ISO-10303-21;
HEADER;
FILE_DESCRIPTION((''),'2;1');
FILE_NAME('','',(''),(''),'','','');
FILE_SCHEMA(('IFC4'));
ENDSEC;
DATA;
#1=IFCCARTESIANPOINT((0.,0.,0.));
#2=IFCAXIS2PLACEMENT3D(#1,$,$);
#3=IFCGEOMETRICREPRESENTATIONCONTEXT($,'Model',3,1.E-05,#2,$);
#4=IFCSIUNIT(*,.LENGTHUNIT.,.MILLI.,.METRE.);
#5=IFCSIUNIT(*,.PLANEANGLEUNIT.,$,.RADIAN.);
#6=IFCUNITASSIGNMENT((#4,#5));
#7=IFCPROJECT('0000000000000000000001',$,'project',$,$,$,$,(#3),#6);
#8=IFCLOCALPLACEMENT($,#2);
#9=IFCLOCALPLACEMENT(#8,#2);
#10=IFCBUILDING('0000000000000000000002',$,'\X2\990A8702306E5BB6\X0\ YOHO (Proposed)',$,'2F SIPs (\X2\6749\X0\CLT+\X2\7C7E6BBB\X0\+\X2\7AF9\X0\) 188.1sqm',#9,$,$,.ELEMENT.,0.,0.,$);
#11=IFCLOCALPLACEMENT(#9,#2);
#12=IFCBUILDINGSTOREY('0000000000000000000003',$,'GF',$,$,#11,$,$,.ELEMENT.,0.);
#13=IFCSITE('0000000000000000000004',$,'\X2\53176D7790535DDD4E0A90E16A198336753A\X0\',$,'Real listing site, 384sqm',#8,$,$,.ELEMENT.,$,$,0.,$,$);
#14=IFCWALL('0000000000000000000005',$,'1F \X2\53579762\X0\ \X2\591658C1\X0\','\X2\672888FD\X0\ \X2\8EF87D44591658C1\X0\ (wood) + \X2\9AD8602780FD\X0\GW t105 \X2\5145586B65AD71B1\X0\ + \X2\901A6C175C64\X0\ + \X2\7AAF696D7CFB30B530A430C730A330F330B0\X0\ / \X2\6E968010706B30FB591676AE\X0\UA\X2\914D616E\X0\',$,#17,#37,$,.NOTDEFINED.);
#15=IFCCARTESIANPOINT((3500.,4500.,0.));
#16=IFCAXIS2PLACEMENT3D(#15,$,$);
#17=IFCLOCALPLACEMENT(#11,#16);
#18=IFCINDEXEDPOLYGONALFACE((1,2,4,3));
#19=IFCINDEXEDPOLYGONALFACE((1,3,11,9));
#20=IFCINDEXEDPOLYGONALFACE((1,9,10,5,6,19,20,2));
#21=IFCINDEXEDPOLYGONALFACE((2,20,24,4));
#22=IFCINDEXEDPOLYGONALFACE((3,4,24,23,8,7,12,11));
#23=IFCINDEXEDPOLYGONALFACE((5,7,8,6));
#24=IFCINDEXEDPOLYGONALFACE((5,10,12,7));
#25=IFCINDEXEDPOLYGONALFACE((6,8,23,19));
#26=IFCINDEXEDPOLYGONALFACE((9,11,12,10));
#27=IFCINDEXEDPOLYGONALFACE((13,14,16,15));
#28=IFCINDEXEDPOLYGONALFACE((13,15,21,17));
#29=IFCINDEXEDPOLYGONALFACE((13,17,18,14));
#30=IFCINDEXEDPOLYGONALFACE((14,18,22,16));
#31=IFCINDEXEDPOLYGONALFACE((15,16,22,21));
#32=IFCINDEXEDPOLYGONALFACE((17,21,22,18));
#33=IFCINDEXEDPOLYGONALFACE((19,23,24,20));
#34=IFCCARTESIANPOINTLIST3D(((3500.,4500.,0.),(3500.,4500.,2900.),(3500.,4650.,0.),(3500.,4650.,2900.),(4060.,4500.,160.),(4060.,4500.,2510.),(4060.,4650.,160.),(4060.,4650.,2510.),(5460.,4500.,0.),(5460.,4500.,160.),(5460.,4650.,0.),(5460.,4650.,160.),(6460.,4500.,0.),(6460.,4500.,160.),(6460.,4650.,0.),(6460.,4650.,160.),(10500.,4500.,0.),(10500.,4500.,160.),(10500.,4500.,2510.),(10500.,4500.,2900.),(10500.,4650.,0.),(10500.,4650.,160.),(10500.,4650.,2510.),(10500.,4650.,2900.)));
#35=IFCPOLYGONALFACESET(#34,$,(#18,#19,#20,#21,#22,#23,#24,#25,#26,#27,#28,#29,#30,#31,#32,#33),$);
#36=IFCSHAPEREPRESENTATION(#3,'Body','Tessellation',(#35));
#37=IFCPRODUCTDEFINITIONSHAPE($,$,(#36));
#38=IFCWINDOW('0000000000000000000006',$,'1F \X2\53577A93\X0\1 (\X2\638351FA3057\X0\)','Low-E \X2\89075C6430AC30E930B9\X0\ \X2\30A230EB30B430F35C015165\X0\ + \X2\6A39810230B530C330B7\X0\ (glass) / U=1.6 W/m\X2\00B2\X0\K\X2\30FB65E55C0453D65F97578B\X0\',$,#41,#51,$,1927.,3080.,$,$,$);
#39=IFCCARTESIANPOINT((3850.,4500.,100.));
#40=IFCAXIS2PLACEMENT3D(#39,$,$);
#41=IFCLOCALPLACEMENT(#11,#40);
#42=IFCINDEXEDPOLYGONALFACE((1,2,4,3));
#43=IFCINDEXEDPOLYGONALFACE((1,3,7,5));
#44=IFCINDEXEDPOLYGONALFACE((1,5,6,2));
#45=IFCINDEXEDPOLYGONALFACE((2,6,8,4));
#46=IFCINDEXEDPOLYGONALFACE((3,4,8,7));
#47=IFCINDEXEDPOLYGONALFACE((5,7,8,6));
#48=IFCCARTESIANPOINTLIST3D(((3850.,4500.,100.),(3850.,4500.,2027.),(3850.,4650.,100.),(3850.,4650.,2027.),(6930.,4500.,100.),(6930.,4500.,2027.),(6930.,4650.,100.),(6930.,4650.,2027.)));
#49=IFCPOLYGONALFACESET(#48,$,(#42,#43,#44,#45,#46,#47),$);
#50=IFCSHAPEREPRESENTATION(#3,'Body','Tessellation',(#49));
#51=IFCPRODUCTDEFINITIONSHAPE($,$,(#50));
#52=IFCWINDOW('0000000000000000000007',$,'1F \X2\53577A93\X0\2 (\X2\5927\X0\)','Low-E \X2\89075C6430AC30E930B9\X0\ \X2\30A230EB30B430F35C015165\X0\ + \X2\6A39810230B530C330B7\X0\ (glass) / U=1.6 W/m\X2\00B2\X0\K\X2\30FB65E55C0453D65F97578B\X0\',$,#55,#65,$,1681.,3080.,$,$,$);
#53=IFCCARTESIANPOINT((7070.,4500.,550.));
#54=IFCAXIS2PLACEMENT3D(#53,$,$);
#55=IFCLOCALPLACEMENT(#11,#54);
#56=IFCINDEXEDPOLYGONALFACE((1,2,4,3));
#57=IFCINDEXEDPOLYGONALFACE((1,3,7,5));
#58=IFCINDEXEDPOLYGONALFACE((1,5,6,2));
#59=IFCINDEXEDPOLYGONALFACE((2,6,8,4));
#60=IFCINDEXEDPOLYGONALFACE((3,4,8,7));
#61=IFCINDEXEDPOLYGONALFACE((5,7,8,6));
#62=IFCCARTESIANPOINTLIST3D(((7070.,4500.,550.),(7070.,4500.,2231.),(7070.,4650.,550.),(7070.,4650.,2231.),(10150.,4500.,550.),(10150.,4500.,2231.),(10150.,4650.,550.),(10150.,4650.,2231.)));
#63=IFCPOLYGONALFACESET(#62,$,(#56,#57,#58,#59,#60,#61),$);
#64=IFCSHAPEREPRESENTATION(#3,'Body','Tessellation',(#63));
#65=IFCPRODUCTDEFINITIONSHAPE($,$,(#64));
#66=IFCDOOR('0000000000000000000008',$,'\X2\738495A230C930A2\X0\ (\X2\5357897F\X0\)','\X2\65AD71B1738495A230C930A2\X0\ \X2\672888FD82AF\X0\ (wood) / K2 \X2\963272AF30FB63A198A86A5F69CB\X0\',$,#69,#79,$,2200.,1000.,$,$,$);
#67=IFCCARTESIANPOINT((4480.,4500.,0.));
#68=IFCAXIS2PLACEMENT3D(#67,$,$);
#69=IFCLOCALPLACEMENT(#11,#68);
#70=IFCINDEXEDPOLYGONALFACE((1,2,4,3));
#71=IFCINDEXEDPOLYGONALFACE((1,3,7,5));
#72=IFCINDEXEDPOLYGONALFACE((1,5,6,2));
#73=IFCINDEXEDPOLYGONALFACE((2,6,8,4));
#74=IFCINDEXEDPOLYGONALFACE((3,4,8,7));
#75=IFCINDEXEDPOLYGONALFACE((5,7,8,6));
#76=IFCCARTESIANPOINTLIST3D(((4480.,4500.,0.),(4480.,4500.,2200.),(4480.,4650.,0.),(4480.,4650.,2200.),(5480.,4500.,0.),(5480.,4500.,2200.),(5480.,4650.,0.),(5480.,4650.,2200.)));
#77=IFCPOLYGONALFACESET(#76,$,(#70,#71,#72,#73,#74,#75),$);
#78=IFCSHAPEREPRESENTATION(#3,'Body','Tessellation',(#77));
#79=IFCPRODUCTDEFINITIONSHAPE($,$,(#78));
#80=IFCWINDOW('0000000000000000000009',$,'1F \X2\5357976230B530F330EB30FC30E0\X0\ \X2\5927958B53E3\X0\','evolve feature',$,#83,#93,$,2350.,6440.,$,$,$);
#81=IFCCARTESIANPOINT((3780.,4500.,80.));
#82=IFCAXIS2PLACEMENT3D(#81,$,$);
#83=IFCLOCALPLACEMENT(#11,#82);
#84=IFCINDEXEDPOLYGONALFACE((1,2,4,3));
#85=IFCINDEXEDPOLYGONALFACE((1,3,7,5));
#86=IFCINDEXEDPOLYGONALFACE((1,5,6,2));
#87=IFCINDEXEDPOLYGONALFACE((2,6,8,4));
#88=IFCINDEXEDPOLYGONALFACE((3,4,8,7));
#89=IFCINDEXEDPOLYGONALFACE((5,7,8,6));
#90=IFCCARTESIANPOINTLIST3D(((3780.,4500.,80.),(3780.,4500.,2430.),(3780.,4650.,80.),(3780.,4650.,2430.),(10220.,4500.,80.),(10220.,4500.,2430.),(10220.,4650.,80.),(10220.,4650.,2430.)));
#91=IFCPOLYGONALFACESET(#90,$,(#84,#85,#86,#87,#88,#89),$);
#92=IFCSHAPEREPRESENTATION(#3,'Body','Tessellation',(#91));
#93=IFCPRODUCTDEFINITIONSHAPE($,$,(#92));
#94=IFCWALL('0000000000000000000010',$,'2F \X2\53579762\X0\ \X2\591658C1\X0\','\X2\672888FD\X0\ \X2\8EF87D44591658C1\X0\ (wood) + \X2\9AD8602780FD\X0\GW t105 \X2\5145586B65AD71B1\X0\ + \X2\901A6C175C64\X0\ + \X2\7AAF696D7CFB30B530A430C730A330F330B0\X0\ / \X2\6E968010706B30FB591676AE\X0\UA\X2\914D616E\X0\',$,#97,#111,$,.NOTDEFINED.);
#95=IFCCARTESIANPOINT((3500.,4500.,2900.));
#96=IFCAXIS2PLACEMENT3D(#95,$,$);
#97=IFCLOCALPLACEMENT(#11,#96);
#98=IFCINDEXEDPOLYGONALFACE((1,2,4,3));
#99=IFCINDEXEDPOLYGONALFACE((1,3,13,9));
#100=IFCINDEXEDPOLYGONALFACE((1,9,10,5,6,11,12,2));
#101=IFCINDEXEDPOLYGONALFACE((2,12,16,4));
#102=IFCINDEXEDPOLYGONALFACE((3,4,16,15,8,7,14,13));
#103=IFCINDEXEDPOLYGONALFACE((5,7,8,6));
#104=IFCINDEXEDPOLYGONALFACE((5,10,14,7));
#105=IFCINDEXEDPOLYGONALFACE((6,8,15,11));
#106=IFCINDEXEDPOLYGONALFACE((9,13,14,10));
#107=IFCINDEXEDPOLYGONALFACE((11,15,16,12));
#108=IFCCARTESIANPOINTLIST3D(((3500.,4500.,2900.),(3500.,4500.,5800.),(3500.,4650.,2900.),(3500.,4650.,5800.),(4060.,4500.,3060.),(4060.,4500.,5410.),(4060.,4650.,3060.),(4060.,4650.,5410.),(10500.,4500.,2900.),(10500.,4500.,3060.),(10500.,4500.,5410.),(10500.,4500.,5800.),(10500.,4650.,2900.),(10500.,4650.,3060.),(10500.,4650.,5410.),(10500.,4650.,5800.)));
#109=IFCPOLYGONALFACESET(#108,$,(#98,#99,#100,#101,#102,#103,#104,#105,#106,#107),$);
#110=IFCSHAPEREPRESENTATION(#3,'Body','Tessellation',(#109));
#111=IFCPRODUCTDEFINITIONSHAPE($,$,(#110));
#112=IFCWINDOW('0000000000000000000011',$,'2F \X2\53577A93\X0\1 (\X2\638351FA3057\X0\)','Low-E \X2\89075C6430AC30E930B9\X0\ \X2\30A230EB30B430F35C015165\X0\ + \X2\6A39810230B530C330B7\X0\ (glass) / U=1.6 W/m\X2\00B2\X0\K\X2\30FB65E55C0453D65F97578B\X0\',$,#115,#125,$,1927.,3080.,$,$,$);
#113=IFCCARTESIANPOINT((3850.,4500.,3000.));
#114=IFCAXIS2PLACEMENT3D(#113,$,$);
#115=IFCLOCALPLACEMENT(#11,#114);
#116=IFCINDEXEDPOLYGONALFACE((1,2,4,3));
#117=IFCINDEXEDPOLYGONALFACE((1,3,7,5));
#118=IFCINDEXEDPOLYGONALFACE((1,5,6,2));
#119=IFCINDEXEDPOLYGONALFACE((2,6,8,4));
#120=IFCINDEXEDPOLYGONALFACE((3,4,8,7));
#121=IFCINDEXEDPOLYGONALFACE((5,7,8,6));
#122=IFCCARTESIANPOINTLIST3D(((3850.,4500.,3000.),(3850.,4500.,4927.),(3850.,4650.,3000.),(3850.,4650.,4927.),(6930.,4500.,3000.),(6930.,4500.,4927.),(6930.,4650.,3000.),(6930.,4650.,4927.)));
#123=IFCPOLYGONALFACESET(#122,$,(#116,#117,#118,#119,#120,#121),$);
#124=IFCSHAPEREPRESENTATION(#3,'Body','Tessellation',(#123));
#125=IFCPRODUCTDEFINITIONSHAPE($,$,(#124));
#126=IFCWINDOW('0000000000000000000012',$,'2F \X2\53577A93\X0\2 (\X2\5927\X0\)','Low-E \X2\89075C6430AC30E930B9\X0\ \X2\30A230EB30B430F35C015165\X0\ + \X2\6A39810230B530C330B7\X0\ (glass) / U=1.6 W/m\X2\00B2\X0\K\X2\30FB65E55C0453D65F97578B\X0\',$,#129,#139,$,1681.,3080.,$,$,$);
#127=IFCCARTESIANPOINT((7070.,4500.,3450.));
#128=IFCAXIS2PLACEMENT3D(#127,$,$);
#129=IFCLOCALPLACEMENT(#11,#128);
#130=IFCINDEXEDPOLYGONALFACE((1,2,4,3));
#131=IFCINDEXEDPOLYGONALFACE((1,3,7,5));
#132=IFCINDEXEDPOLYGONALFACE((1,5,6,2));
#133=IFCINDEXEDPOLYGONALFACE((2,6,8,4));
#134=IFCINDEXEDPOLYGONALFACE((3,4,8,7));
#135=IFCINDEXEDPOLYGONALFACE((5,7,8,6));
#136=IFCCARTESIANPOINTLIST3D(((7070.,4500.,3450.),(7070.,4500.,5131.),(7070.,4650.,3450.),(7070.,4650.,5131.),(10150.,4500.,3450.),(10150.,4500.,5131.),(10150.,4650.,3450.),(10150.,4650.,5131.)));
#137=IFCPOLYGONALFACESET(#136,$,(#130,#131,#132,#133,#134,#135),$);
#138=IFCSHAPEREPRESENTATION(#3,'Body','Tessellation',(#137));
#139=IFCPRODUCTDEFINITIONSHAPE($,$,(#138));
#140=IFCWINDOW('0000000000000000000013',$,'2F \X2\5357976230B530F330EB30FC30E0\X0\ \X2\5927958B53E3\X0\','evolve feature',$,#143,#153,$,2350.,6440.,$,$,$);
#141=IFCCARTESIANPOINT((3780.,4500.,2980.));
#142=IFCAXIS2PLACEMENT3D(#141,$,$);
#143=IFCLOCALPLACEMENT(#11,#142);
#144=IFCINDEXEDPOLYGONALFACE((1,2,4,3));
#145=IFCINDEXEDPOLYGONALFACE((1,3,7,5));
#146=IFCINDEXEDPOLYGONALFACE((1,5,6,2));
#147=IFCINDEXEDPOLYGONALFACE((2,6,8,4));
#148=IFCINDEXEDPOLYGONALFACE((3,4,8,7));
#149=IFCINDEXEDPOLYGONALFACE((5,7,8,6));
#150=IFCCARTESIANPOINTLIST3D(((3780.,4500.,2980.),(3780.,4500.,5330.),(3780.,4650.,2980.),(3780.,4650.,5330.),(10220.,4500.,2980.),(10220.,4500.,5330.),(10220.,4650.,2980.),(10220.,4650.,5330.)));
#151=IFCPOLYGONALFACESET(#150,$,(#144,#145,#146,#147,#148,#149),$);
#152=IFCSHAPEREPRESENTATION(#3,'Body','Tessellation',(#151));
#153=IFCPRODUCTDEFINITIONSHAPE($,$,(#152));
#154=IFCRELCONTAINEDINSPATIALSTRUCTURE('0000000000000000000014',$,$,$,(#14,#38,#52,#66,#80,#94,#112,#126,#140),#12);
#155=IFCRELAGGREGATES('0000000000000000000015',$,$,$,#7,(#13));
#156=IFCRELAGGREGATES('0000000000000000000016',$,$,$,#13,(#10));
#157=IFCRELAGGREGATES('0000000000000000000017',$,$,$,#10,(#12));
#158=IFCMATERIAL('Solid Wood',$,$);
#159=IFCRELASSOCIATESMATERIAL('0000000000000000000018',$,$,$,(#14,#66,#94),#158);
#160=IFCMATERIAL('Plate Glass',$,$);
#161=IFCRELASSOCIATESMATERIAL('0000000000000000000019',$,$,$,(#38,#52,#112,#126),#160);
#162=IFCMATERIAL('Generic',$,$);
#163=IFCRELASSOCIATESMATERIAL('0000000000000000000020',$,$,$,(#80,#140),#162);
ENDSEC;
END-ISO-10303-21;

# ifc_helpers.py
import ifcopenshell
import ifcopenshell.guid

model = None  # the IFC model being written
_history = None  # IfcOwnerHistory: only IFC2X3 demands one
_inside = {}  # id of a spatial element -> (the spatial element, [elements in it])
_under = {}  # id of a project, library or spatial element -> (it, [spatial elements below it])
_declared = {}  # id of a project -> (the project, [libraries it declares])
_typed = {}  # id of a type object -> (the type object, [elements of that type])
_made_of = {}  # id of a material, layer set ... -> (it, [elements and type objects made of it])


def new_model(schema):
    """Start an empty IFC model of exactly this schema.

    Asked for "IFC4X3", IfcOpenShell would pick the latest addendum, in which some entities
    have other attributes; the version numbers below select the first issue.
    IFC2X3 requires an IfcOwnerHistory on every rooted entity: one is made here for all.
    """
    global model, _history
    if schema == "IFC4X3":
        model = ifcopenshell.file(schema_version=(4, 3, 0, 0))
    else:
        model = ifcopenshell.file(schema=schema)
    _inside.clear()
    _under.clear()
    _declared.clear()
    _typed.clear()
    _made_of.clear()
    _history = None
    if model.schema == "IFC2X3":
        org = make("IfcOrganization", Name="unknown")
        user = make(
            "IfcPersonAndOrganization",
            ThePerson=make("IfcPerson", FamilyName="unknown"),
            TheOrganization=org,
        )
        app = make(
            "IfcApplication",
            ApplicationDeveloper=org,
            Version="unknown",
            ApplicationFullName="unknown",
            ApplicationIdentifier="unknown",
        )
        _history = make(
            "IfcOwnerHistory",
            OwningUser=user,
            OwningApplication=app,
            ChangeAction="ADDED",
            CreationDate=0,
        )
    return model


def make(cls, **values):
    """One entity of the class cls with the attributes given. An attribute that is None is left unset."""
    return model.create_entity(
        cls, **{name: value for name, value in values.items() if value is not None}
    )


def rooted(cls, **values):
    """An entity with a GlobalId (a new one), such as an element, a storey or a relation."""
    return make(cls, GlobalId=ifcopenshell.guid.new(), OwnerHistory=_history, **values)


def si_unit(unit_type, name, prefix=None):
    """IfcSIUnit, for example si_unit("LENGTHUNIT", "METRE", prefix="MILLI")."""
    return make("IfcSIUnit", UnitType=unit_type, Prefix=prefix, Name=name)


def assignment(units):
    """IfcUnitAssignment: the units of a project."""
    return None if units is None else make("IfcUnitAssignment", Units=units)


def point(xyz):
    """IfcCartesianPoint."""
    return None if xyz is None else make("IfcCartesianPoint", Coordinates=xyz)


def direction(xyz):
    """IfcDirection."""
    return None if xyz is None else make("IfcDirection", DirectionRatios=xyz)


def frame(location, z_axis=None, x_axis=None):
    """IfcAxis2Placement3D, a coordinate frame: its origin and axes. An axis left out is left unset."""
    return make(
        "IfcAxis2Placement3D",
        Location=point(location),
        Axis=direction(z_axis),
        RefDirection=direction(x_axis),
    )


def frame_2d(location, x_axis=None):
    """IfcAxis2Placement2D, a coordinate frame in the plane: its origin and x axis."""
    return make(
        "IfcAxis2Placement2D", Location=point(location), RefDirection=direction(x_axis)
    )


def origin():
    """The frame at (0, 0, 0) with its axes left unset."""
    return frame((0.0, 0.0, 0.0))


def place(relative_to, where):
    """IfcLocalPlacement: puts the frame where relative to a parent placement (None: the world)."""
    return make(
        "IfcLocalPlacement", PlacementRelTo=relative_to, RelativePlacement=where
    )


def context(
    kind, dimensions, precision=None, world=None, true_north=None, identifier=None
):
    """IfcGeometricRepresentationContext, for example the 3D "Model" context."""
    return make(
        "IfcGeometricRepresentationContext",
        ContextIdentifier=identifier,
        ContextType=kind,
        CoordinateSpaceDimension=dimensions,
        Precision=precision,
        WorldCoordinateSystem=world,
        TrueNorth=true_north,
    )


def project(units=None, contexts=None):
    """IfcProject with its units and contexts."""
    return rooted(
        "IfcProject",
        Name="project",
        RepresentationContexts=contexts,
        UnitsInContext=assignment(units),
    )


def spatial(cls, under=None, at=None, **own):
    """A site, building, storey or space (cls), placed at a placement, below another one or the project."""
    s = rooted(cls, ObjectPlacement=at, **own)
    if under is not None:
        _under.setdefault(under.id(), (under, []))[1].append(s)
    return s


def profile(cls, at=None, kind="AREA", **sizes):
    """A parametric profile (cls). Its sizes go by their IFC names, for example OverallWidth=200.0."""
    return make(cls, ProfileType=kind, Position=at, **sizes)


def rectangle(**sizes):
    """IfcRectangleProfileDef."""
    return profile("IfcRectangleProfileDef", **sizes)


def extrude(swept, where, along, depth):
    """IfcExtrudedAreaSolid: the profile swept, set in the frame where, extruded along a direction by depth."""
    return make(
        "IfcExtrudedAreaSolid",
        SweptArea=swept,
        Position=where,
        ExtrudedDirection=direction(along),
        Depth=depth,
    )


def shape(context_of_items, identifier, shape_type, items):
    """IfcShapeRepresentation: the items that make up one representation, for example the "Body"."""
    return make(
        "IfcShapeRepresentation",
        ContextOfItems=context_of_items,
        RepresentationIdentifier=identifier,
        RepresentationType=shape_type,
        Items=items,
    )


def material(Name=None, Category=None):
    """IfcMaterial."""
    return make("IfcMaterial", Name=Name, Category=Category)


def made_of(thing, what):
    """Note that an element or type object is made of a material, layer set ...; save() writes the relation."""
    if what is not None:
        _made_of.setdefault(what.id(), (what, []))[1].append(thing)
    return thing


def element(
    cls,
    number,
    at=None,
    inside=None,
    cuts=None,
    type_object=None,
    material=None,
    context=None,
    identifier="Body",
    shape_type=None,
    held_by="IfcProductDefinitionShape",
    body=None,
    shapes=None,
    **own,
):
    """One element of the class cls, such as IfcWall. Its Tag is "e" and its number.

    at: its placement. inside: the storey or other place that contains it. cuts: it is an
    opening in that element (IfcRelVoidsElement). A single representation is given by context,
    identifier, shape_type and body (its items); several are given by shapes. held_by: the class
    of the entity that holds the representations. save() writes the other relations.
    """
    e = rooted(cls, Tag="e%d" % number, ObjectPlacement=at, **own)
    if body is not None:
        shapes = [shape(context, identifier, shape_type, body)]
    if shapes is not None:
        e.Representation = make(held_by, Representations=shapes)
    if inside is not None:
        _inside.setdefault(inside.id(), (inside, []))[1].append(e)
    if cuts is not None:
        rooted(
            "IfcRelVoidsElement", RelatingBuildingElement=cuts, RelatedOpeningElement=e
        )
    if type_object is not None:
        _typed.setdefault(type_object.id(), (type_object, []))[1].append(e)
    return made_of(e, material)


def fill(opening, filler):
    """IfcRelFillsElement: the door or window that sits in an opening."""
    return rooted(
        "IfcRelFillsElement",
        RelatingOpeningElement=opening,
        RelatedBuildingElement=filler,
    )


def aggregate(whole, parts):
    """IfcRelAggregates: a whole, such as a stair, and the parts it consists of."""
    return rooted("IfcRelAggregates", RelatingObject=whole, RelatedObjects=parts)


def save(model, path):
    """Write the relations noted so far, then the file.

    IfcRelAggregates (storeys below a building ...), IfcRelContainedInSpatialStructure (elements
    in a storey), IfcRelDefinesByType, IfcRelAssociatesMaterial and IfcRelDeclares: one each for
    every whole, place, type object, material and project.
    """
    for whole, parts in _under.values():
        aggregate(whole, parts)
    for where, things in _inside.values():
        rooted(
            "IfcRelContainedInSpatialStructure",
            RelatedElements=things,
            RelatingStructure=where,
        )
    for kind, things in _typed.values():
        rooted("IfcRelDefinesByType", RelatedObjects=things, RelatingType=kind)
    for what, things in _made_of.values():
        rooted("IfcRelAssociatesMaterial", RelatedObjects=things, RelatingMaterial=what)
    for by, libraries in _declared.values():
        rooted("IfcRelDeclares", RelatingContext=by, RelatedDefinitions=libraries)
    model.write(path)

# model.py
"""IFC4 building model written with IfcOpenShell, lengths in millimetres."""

from ifc_helpers import new_model, si_unit, frame, frame_2d, origin, place, context, project, spatial, rectangle, extrude, material, element, fill, save


model = new_model("IFC4")

# Units and contexts
model_context = context("Model", 3, precision=1e-05, world=origin())
ifc_project = project(units=[si_unit("LENGTHUNIT", "METRE", prefix="MILLI"), si_unit("PLANEANGLEUNIT", "RADIAN")], contexts=[model_context])

# Site, building, storey
site_placement = place(None, origin())
site = spatial("IfcSite", under=ifc_project, at=site_placement, Name="北海道川上郡標茶町", ObjectType="Real listing site, 384sqm", CompositionType="ELEMENT", RefElevation=0.0)
building_placement = place(site_placement, origin())
building = spatial("IfcBuilding", under=site, at=building_placement, Name="養蜂の家 YOHO (Proposed)", ObjectType="2F SIPs (杉CLT+籾殻+竹) 188.1sqm", CompositionType="ELEMENT", ElevationOfRefHeight=0.0, ElevationOfTerrain=0.0)
storey_placement = place(building_placement, origin())
storey = spatial("IfcBuildingStorey", under=building, at=storey_placement, Name="GF", CompositionType="ELEMENT", Elevation=0.0)

# Shared definitions
ifc_material_1 = material(Name="Solid Wood")

# Wall, openings, windows, door
wall_1_placement = place(storey_placement, frame((3500.0, 4500.0, 0.0)))
wall_1 = element("IfcWall", 1, at=wall_1_placement, inside=storey, material=ifc_material_1, Name="1F 南面 外壁", Description="木製 軸組外壁 (wood) + 高性能GW t105 充填断熱 + 通気層 + 窯業系サイディング / 準耐火・外皮UA配慮", PredefinedType="NOTDEFINED", context=model_context, shape_type="SweptSolid", body=[
    extrude(rectangle(XDim=7000.0, YDim=150.0, at=frame_2d((3500.0, 75.0))), frame((3500.0, 4500.0, 0.0)), (0.0, 0.0, 1.0), 2900.0),
])
opening_1_placement = place(storey_placement, frame((3850.0, 4500.0, 100.0)))
opening_1 = element("IfcOpeningElement", 2, at=opening_1_placement, cuts=wall_1, PredefinedType="NOTDEFINED", context=model_context, shape_type="SweptSolid", body=[
    extrude(rectangle(XDim=3080.0, YDim=150.0, at=frame_2d((1540.0, 75.0))), frame((3850.0, 4500.0, 100.0)), (0.0, 0.0, 1.0), 1927.0),
])
opening_2_placement = place(storey_placement, frame((7070.0, 4500.0, 550.0)))
opening_2 = element("IfcOpeningElement", 3, at=opening_2_placement, cuts=wall_1, PredefinedType="NOTDEFINED", context=model_context, shape_type="SweptSolid", body=[
    extrude(rectangle(XDim=3080.0, YDim=150.0, at=frame_2d((1540.0, 75.0))), frame((7070.0, 4500.0, 550.0)), (0.0, 0.0, 1.0), 1681.0),
])
opening_3_placement = place(storey_placement, frame((4480.0, 4500.0, 0.0)))
opening_3 = element("IfcOpeningElement", 4, at=opening_3_placement, cuts=wall_1, PredefinedType="NOTDEFINED", context=model_context, shape_type="SweptSolid", body=[
    extrude(rectangle(XDim=1000.0, YDim=150.0, at=frame_2d((500.0, 75.0))), frame((4480.0, 4500.0, 0.0)), (0.0, 0.0, 1.0), 2200.0),
])
opening_4_placement = place(storey_placement, frame((3780.0, 4500.0, 80.0)))
opening_4 = element("IfcOpeningElement", 5, at=opening_4_placement, cuts=wall_1, PredefinedType="NOTDEFINED", context=model_context, shape_type="SweptSolid", body=[
    extrude(rectangle(XDim=6440.0, YDim=150.0, at=frame_2d((3220.0, 75.0))), frame((3780.0, 4500.0, 80.0)), (0.0, 0.0, 1.0), 2350.0),
])
ifc_material_2 = material(Name="Plate Glass")
window_1_placement = place(storey_placement, frame((3850.0, 4500.0, 100.0)))
window_1 = element("IfcWindow", 6, at=window_1_placement, inside=storey, material=ifc_material_2, Name="1F 南窓1 (掃出し)", Description="Low-E 複層ガラス アルゴン封入 + 樹脂サッシ (glass) / U=1.6 W/m²K・日射取得型", OverallHeight=1927.0, OverallWidth=3080.0, context=model_context, shape_type="SweptSolid", body=[
    extrude(rectangle(XDim=3080.0, YDim=150.0, at=frame_2d((1540.0, 75.0))), frame((3850.0, 4500.0, 100.0)), (0.0, 0.0, 1.0), 1927.0),
])
fill(opening_1, window_1)
window_2_placement = place(storey_placement, frame((7070.0, 4500.0, 550.0)))
window_2 = element("IfcWindow", 7, at=window_2_placement, inside=storey, material=ifc_material_2, Name="1F 南窓2 (大)", Description="Low-E 複層ガラス アルゴン封入 + 樹脂サッシ (glass) / U=1.6 W/m²K・日射取得型", OverallHeight=1681.0, OverallWidth=3080.0, context=model_context, shape_type="SweptSolid", body=[
    extrude(rectangle(XDim=3080.0, YDim=150.0, at=frame_2d((1540.0, 75.0))), frame((7070.0, 4500.0, 550.0)), (0.0, 0.0, 1.0), 1681.0),
])
fill(opening_2, window_2)
door_placement = place(storey_placement, frame((4480.0, 4500.0, 0.0)))
door = element("IfcDoor", 8, at=door_placement, inside=storey, material=ifc_material_1, Name="玄関ドア (南西)", Description="断熱玄関ドア 木製芯 (wood) / K2 防犯・採風機構", OverallHeight=2200.0, OverallWidth=1000.0, context=model_context, shape_type="SweptSolid", body=[
    extrude(rectangle(XDim=1000.0, YDim=150.0, at=frame_2d((500.0, 75.0))), frame((4480.0, 4500.0, 0.0)), (0.0, 0.0, 1.0), 2200.0),
])
fill(opening_3, door)
ifc_material_3 = material(Name="Generic")
window_3_placement = place(storey_placement, frame((3780.0, 4500.0, 80.0)))
window_3 = element("IfcWindow", 9, at=window_3_placement, inside=storey, material=ifc_material_3, Name="1F 南面サンルーム 大開口", Description="evolve feature", OverallHeight=2350.0, OverallWidth=6440.0, context=model_context, shape_type="SweptSolid", body=[
    extrude(rectangle(XDim=6440.0, YDim=150.0, at=frame_2d((3220.0, 75.0))), frame((3780.0, 4500.0, 80.0)), (0.0, 0.0, 1.0), 2350.0),
])
fill(opening_4, window_3)

# Wall, openings, windows
wall_2_placement = place(storey_placement, frame((3500.0, 4500.0, 2900.0)))
wall_2 = element("IfcWall", 10, at=wall_2_placement, inside=storey, material=ifc_material_1, Name="2F 南面 外壁", Description="木製 軸組外壁 (wood) + 高性能GW t105 充填断熱 + 通気層 + 窯業系サイディング / 準耐火・外皮UA配慮", PredefinedType="NOTDEFINED", context=model_context, shape_type="SweptSolid", body=[
    extrude(rectangle(XDim=7000.0, YDim=150.0, at=frame_2d((3500.0, 75.0))), frame((3500.0, 4500.0, 2900.0)), (0.0, 0.0, 1.0), 2900.0),
])
opening_5_placement = place(storey_placement, frame((3850.0, 4500.0, 3000.0)))
opening_5 = element("IfcOpeningElement", 11, at=opening_5_placement, cuts=wall_2, PredefinedType="NOTDEFINED", context=model_context, shape_type="SweptSolid", body=[
    extrude(rectangle(XDim=3080.0, YDim=150.0, at=frame_2d((1540.0, 75.0))), frame((3850.0, 4500.0, 3000.0)), (0.0, 0.0, 1.0), 1927.0),
])
opening_6_placement = place(storey_placement, frame((7070.0, 4500.0, 3450.0)))
opening_6 = element("IfcOpeningElement", 12, at=opening_6_placement, cuts=wall_2, PredefinedType="NOTDEFINED", context=model_context, shape_type="SweptSolid", body=[
    extrude(rectangle(XDim=3080.0, YDim=150.0, at=frame_2d((1540.0, 75.0))), frame((7070.0, 4500.0, 3450.0)), (0.0, 0.0, 1.0), 1681.0),
])
opening_7_placement = place(storey_placement, frame((3780.0, 4500.0, 2980.0)))
opening_7 = element("IfcOpeningElement", 13, at=opening_7_placement, cuts=wall_2, PredefinedType="NOTDEFINED", context=model_context, shape_type="SweptSolid", body=[
    extrude(rectangle(XDim=6440.0, YDim=150.0, at=frame_2d((3220.0, 75.0))), frame((3780.0, 4500.0, 2980.0)), (0.0, 0.0, 1.0), 2350.0),
])
window_4_placement = place(storey_placement, frame((3850.0, 4500.0, 3000.0)))
window_4 = element("IfcWindow", 14, at=window_4_placement, inside=storey, material=ifc_material_2, Name="2F 南窓1 (掃出し)", Description="Low-E 複層ガラス アルゴン封入 + 樹脂サッシ (glass) / U=1.6 W/m²K・日射取得型", OverallHeight=1927.0, OverallWidth=3080.0, context=model_context, shape_type="SweptSolid", body=[
    extrude(rectangle(XDim=3080.0, YDim=150.0, at=frame_2d((1540.0, 75.0))), frame((3850.0, 4500.0, 3000.0)), (0.0, 0.0, 1.0), 1927.0),
])
fill(opening_5, window_4)
window_5_placement = place(storey_placement, frame((7070.0, 4500.0, 3450.0)))
window_5 = element("IfcWindow", 15, at=window_5_placement, inside=storey, material=ifc_material_2, Name="2F 南窓2 (大)", Description="Low-E 複層ガラス アルゴン封入 + 樹脂サッシ (glass) / U=1.6 W/m²K・日射取得型", OverallHeight=1681.0, OverallWidth=3080.0, context=model_context, shape_type="SweptSolid", body=[
    extrude(rectangle(XDim=3080.0, YDim=150.0, at=frame_2d((1540.0, 75.0))), frame((7070.0, 4500.0, 3450.0)), (0.0, 0.0, 1.0), 1681.0),
])
fill(opening_6, window_5)
window_6_placement = place(storey_placement, frame((3780.0, 4500.0, 2980.0)))
window_6 = element("IfcWindow", 16, at=window_6_placement, inside=storey, material=ifc_material_3, Name="2F 南面サンルーム 大開口", Description="evolve feature", OverallHeight=2350.0, OverallWidth=6440.0, context=model_context, shape_type="SweptSolid", body=[
    extrude(rectangle(XDim=6440.0, YDim=150.0, at=frame_2d((3220.0, 75.0))), frame((3780.0, 4500.0, 2980.0)), (0.0, 0.0, 1.0), 2350.0),
])
fill(opening_7, window_6)

save(model, "model.ifc")
